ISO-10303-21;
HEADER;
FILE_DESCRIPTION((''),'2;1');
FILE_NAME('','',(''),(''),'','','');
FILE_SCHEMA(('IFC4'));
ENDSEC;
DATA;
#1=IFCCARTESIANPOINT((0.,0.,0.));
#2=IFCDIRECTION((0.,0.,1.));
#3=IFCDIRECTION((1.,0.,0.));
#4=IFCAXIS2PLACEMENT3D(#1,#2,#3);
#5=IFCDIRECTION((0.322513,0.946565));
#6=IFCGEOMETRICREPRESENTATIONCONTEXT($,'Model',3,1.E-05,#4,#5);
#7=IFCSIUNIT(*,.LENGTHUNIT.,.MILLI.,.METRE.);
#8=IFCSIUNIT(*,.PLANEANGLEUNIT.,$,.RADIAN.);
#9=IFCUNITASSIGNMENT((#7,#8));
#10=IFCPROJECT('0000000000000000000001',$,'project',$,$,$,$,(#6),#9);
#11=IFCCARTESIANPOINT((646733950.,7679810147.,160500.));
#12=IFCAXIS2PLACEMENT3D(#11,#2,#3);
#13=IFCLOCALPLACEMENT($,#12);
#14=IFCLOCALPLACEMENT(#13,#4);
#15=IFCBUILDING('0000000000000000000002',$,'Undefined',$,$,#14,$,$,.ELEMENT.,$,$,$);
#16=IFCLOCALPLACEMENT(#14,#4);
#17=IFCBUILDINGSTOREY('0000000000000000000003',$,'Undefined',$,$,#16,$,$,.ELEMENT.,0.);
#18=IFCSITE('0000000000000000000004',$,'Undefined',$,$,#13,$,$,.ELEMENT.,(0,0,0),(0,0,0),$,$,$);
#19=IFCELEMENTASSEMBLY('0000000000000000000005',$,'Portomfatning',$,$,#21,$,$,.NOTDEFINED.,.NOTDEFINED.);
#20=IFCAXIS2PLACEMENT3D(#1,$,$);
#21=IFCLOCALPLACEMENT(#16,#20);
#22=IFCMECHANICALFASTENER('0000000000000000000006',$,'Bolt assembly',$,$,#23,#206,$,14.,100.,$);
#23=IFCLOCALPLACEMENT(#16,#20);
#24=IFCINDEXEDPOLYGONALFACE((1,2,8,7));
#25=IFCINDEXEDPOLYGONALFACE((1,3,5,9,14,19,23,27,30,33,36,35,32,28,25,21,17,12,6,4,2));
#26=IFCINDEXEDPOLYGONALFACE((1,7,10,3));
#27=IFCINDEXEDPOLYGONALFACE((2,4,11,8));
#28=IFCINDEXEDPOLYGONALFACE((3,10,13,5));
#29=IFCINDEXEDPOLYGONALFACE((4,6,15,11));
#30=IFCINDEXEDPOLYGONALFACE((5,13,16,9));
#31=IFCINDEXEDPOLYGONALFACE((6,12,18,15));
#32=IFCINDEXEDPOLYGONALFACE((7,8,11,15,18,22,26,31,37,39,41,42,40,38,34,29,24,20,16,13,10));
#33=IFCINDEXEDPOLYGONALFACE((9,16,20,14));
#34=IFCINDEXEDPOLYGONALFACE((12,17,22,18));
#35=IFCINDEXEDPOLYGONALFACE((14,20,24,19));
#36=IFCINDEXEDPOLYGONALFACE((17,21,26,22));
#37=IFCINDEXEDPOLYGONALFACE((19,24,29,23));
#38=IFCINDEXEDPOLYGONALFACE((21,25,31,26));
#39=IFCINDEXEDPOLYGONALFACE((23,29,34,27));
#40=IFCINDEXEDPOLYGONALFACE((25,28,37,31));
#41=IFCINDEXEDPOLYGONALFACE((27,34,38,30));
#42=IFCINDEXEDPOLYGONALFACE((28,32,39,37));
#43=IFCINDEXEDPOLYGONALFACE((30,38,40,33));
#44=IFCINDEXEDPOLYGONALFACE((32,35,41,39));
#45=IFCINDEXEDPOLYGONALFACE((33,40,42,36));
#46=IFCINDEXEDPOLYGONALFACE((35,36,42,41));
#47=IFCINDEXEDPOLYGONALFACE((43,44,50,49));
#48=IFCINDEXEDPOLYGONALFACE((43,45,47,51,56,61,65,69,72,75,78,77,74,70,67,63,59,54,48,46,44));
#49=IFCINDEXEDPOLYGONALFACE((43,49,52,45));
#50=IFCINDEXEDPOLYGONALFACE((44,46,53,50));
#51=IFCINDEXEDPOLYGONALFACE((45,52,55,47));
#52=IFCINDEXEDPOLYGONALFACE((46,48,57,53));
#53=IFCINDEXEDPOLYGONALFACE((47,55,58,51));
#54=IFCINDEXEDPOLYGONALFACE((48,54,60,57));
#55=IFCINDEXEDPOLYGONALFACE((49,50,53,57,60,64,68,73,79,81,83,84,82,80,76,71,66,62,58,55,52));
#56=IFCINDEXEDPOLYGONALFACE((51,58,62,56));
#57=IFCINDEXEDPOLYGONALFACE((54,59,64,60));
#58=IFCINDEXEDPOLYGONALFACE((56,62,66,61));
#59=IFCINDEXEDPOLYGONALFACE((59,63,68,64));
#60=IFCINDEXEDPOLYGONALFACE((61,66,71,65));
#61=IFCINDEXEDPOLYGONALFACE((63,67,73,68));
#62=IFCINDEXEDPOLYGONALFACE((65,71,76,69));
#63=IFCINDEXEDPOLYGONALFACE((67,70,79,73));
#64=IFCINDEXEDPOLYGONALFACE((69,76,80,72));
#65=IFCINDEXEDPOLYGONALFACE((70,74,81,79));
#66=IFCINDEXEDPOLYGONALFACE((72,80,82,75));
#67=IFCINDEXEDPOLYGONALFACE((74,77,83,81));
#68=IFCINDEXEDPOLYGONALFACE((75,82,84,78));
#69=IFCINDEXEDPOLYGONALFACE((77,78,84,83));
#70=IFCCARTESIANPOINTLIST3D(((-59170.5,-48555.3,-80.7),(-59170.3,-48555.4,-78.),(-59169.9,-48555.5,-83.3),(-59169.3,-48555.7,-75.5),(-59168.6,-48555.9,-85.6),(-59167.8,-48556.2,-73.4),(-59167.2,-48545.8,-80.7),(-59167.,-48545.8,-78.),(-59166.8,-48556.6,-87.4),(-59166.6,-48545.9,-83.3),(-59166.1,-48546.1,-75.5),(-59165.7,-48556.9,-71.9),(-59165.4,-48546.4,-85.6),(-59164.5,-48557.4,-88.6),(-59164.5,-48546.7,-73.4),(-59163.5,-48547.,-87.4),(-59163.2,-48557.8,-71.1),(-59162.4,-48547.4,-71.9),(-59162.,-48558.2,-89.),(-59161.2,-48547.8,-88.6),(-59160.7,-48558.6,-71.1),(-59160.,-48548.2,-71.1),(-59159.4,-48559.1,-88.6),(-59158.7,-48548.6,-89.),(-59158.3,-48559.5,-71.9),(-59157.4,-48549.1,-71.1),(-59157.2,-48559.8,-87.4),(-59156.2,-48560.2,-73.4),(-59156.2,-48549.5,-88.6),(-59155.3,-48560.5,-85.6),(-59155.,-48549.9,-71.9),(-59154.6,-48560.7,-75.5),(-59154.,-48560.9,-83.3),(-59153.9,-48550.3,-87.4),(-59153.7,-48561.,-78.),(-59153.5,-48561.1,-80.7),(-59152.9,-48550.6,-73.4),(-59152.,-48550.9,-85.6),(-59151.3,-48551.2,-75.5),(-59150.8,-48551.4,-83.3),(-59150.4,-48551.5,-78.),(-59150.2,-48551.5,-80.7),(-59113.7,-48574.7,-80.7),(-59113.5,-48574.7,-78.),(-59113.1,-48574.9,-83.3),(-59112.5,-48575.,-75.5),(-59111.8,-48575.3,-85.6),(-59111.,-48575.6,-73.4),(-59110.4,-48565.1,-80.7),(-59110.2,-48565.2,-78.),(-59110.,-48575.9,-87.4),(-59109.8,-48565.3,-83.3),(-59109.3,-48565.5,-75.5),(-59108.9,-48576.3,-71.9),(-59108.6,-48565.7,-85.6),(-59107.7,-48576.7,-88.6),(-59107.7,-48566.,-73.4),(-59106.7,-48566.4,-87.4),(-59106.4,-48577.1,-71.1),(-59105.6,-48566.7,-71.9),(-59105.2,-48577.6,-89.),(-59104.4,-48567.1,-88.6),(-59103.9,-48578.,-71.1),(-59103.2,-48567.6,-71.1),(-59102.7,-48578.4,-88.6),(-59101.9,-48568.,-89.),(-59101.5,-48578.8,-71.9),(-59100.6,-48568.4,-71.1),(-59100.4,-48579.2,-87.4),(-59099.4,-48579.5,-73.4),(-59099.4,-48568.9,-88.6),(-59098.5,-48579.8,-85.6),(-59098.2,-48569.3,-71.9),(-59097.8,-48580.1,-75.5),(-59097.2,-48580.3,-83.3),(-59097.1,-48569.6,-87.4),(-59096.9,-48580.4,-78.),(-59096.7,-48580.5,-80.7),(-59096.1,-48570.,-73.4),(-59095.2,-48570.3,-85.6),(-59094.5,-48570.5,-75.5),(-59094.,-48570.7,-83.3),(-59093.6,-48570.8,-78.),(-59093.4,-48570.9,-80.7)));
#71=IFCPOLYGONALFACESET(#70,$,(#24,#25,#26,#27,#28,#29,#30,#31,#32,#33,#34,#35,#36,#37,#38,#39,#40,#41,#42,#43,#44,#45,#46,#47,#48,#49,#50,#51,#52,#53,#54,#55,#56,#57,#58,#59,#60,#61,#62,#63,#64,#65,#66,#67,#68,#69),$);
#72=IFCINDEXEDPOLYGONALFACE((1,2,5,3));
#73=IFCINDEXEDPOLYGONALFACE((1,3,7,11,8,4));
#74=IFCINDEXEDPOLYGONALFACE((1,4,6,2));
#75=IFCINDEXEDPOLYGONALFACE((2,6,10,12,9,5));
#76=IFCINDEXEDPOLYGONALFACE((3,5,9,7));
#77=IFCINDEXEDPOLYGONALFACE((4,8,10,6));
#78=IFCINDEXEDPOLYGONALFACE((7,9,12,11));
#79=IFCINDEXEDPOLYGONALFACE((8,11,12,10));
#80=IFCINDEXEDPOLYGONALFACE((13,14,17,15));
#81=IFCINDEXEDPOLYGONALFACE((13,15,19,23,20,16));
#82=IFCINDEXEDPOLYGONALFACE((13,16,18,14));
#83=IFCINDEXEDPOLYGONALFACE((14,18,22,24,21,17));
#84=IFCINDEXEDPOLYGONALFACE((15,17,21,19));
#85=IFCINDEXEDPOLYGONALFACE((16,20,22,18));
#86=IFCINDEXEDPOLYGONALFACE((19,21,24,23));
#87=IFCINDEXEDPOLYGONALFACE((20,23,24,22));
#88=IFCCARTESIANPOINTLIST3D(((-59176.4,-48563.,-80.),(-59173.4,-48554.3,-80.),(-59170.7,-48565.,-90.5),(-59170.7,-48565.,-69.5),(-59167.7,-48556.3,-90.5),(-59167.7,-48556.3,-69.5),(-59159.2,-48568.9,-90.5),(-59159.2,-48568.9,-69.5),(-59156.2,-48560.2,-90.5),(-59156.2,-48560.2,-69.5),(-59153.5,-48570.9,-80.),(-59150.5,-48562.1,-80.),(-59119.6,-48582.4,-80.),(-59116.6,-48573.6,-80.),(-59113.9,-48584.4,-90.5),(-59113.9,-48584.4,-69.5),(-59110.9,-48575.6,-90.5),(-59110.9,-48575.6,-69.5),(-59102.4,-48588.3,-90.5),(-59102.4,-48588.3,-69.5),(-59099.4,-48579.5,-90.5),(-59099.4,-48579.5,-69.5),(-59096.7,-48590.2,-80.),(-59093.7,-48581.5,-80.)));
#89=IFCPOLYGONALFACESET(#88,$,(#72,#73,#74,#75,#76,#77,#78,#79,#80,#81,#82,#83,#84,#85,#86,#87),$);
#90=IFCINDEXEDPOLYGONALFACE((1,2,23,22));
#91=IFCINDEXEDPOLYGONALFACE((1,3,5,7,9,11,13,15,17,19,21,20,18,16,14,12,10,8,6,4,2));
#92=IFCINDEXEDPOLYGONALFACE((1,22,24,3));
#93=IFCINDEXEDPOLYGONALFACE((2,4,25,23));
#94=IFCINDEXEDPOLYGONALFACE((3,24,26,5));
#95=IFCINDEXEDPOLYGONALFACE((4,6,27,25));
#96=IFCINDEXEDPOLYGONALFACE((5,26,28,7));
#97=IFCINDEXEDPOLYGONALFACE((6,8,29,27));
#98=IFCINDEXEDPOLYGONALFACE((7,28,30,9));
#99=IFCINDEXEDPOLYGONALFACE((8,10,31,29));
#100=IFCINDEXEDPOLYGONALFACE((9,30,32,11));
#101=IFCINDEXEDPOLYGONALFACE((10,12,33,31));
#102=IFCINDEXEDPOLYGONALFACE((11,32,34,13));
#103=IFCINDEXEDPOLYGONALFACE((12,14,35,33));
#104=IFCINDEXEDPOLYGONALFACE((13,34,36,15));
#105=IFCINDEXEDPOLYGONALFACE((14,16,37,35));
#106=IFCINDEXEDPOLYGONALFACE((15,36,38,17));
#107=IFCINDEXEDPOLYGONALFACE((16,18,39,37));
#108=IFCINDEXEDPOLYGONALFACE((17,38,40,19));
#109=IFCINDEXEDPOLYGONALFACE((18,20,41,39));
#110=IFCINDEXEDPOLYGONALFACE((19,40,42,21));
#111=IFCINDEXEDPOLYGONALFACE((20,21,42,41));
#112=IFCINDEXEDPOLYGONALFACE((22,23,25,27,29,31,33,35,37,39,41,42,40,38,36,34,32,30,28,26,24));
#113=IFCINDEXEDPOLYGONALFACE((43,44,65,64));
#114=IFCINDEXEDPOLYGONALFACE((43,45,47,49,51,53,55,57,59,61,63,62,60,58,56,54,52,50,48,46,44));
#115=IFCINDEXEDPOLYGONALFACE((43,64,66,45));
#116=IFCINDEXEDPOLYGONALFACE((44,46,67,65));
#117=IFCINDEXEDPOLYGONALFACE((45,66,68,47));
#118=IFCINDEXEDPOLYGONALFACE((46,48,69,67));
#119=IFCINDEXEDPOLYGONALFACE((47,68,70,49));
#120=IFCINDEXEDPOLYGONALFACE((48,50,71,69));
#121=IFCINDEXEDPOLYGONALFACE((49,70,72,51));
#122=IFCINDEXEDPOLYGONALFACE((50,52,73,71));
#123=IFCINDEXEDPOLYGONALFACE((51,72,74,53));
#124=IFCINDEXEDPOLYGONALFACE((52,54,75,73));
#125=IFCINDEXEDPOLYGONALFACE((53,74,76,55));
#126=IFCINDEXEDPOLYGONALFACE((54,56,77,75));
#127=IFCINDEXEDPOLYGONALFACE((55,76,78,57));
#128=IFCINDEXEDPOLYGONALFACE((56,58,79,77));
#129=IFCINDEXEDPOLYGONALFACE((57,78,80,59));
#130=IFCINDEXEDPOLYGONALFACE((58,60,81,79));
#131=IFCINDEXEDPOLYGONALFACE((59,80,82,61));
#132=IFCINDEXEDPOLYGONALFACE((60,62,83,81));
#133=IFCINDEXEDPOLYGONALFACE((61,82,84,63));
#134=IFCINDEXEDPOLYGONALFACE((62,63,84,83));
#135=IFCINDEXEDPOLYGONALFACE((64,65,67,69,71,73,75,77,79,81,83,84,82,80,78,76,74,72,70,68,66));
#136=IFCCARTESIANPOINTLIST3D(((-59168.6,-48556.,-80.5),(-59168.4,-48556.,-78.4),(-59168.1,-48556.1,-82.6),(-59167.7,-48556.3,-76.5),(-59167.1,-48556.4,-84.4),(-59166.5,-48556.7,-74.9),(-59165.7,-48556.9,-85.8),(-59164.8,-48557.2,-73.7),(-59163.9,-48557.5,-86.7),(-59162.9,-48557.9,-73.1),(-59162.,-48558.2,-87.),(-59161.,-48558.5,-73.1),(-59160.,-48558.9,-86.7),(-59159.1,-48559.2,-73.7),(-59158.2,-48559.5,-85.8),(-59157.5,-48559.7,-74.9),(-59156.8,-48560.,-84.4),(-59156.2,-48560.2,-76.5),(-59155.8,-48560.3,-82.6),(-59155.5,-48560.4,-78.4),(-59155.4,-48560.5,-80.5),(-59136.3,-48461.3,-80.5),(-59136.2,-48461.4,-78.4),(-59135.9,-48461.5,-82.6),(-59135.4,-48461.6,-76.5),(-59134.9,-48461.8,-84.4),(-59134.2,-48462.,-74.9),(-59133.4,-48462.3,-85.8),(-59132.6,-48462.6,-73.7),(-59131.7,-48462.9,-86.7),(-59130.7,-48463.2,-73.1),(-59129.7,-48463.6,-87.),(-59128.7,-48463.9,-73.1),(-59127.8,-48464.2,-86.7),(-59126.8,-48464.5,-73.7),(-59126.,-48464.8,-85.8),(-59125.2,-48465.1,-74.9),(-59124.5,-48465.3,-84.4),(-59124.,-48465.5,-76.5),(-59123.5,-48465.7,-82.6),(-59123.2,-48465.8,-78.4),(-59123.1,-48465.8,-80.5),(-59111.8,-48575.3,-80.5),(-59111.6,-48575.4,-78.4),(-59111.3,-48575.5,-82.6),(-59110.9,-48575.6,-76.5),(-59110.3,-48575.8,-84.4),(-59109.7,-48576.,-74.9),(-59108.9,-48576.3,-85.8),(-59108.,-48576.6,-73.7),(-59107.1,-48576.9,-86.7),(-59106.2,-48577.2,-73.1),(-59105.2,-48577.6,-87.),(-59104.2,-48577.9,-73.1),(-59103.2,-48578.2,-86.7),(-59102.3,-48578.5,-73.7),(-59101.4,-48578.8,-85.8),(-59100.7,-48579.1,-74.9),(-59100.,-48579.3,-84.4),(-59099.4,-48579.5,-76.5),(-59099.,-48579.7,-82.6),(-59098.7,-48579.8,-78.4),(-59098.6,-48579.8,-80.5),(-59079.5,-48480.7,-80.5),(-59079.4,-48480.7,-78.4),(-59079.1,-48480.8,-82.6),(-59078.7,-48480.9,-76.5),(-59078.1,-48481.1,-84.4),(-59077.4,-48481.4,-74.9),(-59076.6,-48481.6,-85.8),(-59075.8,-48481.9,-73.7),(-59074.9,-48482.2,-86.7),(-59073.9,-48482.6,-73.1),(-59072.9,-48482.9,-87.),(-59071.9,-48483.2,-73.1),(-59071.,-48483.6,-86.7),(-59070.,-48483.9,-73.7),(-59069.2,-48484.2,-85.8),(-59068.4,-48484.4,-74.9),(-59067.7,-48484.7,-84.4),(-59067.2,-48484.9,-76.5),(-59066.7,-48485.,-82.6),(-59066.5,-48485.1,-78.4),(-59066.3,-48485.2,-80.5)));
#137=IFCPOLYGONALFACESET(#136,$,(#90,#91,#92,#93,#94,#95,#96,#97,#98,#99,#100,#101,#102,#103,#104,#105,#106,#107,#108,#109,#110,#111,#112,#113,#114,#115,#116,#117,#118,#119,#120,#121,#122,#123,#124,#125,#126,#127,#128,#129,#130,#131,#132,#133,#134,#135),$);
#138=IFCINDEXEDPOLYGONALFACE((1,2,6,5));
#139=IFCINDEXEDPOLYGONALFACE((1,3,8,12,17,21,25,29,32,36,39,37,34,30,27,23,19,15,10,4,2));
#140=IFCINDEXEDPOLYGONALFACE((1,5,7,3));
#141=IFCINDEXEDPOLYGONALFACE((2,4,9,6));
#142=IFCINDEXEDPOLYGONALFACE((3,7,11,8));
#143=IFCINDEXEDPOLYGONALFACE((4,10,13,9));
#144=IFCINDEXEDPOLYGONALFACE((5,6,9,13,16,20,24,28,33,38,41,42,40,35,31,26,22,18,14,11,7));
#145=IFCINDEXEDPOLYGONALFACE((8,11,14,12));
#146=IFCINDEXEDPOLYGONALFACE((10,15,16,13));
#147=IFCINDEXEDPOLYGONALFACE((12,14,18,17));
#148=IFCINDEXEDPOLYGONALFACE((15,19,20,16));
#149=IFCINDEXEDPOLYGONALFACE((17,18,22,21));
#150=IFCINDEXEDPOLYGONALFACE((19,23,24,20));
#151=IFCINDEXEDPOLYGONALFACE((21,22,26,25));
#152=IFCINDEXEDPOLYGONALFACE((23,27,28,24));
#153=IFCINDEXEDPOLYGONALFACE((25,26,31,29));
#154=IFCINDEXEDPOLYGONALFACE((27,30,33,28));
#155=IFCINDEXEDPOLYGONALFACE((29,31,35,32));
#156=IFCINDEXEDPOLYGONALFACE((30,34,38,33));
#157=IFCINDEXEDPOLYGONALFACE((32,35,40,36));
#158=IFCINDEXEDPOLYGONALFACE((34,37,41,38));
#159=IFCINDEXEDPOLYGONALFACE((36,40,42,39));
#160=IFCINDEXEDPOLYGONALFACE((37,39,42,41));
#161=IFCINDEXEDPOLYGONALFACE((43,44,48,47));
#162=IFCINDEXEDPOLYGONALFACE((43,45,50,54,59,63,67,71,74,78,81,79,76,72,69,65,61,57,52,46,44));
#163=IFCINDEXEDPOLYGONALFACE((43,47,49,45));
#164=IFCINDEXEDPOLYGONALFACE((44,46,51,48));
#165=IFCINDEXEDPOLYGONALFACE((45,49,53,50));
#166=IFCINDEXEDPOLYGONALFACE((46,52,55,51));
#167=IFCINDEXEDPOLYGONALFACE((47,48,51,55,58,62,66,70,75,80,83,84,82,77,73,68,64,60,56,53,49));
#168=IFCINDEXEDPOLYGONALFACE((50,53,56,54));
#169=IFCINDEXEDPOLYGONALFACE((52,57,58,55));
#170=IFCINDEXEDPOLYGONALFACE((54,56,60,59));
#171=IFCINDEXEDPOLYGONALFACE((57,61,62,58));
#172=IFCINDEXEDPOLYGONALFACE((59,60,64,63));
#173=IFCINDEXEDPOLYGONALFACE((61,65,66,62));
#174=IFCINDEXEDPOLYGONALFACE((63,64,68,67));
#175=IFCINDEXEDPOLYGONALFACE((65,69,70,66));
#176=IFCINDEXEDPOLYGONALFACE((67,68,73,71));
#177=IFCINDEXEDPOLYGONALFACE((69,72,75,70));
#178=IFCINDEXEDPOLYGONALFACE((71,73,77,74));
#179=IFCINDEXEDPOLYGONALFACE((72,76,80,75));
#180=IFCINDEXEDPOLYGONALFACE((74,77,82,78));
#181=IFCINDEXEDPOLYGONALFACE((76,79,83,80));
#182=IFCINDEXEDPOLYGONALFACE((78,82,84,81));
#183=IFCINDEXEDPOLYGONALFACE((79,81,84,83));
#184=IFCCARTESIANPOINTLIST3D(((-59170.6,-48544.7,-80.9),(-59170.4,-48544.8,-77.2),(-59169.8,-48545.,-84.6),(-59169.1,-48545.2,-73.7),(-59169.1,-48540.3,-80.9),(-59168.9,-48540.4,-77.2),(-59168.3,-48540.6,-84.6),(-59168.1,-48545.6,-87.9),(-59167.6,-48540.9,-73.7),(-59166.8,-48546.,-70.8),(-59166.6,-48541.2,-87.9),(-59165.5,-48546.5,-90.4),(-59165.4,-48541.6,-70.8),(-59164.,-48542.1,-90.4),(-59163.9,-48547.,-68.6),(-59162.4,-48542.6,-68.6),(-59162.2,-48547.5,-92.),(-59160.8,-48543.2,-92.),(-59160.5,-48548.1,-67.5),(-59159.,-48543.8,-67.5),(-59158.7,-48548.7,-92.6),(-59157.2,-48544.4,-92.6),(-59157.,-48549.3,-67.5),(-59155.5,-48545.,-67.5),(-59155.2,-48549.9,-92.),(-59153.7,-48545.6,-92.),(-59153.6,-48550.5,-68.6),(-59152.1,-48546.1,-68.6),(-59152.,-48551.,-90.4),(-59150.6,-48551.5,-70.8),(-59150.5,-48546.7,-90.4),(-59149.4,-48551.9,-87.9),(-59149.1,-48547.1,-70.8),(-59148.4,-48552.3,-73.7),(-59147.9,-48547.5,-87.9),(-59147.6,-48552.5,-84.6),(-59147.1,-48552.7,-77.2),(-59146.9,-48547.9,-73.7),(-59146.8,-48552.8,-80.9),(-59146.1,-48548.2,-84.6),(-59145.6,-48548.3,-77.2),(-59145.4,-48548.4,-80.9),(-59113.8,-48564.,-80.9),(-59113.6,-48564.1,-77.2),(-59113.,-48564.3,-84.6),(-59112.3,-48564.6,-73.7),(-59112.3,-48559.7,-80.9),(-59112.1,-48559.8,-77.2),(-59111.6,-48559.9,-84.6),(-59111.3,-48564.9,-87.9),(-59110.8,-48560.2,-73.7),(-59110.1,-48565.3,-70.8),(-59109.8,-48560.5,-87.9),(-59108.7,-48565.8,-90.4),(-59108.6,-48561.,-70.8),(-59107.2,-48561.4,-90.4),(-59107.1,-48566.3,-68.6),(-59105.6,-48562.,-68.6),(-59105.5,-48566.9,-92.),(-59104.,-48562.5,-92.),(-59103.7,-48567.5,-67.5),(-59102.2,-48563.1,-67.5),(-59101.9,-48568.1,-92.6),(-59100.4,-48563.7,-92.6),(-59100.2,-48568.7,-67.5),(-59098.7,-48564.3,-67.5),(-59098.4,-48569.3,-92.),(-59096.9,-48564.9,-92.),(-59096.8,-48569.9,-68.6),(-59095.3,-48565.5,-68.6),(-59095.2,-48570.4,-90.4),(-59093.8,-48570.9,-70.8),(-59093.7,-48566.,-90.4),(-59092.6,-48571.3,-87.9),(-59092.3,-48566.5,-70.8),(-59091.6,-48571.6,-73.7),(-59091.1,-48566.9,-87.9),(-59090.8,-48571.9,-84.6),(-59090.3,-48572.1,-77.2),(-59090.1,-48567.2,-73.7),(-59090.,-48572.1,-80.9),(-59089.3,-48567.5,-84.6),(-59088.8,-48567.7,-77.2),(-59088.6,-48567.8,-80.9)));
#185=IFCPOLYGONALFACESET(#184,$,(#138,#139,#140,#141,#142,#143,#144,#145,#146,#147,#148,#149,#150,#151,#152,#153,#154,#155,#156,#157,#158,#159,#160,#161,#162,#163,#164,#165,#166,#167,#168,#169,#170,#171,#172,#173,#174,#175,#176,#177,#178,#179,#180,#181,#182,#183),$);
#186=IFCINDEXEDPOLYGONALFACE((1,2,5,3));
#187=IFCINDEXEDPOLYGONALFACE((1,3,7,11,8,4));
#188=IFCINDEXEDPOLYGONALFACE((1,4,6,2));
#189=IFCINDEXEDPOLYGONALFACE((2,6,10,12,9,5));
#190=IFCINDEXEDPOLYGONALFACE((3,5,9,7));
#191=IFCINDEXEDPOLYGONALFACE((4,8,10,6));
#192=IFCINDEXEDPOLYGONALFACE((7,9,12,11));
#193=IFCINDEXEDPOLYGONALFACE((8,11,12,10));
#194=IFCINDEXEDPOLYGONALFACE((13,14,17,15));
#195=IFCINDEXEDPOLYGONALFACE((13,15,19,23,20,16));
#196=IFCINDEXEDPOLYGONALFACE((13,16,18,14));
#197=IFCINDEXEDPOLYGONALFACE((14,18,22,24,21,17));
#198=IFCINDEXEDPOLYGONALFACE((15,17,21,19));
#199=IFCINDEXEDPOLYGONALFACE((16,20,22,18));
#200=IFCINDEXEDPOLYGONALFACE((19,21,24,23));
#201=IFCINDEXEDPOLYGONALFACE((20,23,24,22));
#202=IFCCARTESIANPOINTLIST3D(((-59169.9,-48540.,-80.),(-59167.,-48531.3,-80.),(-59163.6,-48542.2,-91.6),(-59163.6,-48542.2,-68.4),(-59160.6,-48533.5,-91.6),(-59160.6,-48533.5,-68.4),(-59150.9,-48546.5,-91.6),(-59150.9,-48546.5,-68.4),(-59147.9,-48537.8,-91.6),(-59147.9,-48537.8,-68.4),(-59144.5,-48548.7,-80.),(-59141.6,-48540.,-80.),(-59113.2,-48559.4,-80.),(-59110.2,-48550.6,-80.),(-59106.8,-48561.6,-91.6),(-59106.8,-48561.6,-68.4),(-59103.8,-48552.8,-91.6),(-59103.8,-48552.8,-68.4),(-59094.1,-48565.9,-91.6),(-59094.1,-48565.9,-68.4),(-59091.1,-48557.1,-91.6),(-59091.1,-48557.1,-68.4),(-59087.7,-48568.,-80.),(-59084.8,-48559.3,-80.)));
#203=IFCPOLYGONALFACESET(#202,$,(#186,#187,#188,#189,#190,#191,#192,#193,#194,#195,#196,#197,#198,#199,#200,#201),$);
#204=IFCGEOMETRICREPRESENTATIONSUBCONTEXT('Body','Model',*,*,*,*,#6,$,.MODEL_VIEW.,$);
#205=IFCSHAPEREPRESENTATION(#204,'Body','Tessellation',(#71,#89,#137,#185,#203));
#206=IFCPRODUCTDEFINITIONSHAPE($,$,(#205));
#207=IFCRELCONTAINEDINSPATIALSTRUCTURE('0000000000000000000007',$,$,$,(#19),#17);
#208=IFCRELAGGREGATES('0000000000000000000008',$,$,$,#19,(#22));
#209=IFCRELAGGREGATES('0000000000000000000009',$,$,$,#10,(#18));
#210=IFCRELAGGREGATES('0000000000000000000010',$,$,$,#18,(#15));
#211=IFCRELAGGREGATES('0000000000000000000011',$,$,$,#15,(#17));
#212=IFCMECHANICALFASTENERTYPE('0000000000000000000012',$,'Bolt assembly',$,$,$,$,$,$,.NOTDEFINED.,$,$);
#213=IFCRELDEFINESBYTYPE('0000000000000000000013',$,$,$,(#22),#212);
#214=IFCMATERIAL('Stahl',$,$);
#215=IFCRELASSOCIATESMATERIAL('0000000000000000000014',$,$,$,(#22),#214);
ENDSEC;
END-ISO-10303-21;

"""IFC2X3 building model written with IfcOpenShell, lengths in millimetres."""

from ifc_helpers import new_model, si_unit, direction, frame, origin_with_axes, origin_2d_with_axis, place, context, subcontext, project, spatial, polyline, circle, outline, extrude, source, transform, mapped, material, type_object, element, aggregate, save


model = new_model("IFC2X3")

# Units and contexts
model_context = context("Model", 3, precision=1e-05, world=origin_with_axes(), true_north=direction((0.322513, 0.946565)))
body_context = subcontext(model_context, "Body", "Model", "MODEL_VIEW")
ifc_project = project(units=[si_unit("LENGTHUNIT", "METRE", prefix="MILLI"), si_unit("PLANEANGLEUNIT", "RADIAN")], contexts=[model_context])

# Site, building, storey
site_placement = place(None, frame((646733950.0, 7679810147.0, 160500.0), z_axis=(0.0, 0.0, 1.0), x_axis=(1.0, 0.0, 0.0)))
site = spatial("IfcSite", under=ifc_project, at=site_placement, Name="Undefined", CompositionType="ELEMENT", RefLatitude=(0, 0, 0), RefLongitude=(0, 0, 0))
building_placement = place(site_placement, origin_with_axes())
building = spatial("IfcBuilding", under=site, at=building_placement, Name="Undefined", CompositionType="ELEMENT")
storey_placement = place(building_placement, origin_with_axes())
storey = spatial("IfcBuildingStorey", under=building, at=storey_placement, Name="Undefined", CompositionType="ELEMENT", Elevation=0.0)

# Element assembly
assembly_1_placement = place(storey_placement, origin_with_axes())
assembly_1 = element("IfcElementAssembly", 1, at=assembly_1_placement, inside=storey, Name="Portomfatning", AssemblyPlace="NOTDEFINED", PredefinedType="NOTDEFINED")

# Mechanical fastener
mechanical_fastener_type = type_object("IfcMechanicalFastenerType", Name="Bolt assembly")
ifc_material_1 = material(Name="Stahl")
shared_shape_1 = source(origin_with_axes(), body_context, "Body", "SweptSolid", [
    extrude(circle(Radius=9.0, at=origin_2d_with_axis()), frame((0.0, -10.0, 0.0), z_axis=(0.0, 1.0, 0.0), x_axis=(1.0, 0.0, 0.0)), (0.0, 0.0, 1.0), 10.1),
    extrude(outline(polyline([(10.5, -6.1), (10.5, 6.1), (0.0, 12.1), (-10.5, 6.1), (-10.5, -6.1), (0.0, -12.1), (10.5, -6.1)])), frame((0.0, -19.2, 0.0), z_axis=(0.0, 1.0, 0.0), x_axis=(1.0, 0.0, 0.0)), (0.0, 0.0, 1.0), 9.2),
    extrude(circle(Radius=7.0, at=origin_2d_with_axis()), frame((0.0, -10.0, 0.0), z_axis=(0.0, 1.0, 0.0), x_axis=(1.0, 0.0, 0.0)), (0.0, 0.0, 1.0), 100.0),
    extrude(circle(Radius=12.6, at=origin_2d_with_axis()), frame((0.0, 0.0, 0.0), z_axis=(0.0, 1.0, 0.0), x_axis=(1.0, 0.0, 0.0)), (0.0, 0.0, 1.0), 4.6),
    extrude(outline(polyline([(11.6, -6.7), (11.6, 6.7), (0.0, 13.4), (-11.6, 6.7), (-11.6, -6.7), (0.0, -13.4), (11.6, -6.7)])), frame((0.0, 4.6, 0.0), z_axis=(0.0, 1.0, 0.0), x_axis=(1.0, 0.0, 0.0)), (0.0, 0.0, 1.0), 9.2),
])
mechanical_fastener_1_placement = place(assembly_1_placement, frame((-59130.3, -48558.4, -80.0), z_axis=(0.946565, -0.322513, 0.0), x_axis=(0.0, 0.0, -1.0)))
mechanical_fastener_1 = element("IfcMechanicalFastener", 2, at=mechanical_fastener_1_placement, type_object=mechanical_fastener_type, material=ifc_material_1, Name="Bolt assembly", NominalDiameter=14.0, NominalLength=100.0, context=body_context, shape_type="MappedRepresentation", body=[
    mapped(shared_shape_1, transform((0.0, 0.0, -30.0))),
    mapped(shared_shape_1, transform((0.0, 0.0, 30.0))),
])
aggregate(assembly_1, [mechanical_fastener_1])

save(model, "model.ifc")
